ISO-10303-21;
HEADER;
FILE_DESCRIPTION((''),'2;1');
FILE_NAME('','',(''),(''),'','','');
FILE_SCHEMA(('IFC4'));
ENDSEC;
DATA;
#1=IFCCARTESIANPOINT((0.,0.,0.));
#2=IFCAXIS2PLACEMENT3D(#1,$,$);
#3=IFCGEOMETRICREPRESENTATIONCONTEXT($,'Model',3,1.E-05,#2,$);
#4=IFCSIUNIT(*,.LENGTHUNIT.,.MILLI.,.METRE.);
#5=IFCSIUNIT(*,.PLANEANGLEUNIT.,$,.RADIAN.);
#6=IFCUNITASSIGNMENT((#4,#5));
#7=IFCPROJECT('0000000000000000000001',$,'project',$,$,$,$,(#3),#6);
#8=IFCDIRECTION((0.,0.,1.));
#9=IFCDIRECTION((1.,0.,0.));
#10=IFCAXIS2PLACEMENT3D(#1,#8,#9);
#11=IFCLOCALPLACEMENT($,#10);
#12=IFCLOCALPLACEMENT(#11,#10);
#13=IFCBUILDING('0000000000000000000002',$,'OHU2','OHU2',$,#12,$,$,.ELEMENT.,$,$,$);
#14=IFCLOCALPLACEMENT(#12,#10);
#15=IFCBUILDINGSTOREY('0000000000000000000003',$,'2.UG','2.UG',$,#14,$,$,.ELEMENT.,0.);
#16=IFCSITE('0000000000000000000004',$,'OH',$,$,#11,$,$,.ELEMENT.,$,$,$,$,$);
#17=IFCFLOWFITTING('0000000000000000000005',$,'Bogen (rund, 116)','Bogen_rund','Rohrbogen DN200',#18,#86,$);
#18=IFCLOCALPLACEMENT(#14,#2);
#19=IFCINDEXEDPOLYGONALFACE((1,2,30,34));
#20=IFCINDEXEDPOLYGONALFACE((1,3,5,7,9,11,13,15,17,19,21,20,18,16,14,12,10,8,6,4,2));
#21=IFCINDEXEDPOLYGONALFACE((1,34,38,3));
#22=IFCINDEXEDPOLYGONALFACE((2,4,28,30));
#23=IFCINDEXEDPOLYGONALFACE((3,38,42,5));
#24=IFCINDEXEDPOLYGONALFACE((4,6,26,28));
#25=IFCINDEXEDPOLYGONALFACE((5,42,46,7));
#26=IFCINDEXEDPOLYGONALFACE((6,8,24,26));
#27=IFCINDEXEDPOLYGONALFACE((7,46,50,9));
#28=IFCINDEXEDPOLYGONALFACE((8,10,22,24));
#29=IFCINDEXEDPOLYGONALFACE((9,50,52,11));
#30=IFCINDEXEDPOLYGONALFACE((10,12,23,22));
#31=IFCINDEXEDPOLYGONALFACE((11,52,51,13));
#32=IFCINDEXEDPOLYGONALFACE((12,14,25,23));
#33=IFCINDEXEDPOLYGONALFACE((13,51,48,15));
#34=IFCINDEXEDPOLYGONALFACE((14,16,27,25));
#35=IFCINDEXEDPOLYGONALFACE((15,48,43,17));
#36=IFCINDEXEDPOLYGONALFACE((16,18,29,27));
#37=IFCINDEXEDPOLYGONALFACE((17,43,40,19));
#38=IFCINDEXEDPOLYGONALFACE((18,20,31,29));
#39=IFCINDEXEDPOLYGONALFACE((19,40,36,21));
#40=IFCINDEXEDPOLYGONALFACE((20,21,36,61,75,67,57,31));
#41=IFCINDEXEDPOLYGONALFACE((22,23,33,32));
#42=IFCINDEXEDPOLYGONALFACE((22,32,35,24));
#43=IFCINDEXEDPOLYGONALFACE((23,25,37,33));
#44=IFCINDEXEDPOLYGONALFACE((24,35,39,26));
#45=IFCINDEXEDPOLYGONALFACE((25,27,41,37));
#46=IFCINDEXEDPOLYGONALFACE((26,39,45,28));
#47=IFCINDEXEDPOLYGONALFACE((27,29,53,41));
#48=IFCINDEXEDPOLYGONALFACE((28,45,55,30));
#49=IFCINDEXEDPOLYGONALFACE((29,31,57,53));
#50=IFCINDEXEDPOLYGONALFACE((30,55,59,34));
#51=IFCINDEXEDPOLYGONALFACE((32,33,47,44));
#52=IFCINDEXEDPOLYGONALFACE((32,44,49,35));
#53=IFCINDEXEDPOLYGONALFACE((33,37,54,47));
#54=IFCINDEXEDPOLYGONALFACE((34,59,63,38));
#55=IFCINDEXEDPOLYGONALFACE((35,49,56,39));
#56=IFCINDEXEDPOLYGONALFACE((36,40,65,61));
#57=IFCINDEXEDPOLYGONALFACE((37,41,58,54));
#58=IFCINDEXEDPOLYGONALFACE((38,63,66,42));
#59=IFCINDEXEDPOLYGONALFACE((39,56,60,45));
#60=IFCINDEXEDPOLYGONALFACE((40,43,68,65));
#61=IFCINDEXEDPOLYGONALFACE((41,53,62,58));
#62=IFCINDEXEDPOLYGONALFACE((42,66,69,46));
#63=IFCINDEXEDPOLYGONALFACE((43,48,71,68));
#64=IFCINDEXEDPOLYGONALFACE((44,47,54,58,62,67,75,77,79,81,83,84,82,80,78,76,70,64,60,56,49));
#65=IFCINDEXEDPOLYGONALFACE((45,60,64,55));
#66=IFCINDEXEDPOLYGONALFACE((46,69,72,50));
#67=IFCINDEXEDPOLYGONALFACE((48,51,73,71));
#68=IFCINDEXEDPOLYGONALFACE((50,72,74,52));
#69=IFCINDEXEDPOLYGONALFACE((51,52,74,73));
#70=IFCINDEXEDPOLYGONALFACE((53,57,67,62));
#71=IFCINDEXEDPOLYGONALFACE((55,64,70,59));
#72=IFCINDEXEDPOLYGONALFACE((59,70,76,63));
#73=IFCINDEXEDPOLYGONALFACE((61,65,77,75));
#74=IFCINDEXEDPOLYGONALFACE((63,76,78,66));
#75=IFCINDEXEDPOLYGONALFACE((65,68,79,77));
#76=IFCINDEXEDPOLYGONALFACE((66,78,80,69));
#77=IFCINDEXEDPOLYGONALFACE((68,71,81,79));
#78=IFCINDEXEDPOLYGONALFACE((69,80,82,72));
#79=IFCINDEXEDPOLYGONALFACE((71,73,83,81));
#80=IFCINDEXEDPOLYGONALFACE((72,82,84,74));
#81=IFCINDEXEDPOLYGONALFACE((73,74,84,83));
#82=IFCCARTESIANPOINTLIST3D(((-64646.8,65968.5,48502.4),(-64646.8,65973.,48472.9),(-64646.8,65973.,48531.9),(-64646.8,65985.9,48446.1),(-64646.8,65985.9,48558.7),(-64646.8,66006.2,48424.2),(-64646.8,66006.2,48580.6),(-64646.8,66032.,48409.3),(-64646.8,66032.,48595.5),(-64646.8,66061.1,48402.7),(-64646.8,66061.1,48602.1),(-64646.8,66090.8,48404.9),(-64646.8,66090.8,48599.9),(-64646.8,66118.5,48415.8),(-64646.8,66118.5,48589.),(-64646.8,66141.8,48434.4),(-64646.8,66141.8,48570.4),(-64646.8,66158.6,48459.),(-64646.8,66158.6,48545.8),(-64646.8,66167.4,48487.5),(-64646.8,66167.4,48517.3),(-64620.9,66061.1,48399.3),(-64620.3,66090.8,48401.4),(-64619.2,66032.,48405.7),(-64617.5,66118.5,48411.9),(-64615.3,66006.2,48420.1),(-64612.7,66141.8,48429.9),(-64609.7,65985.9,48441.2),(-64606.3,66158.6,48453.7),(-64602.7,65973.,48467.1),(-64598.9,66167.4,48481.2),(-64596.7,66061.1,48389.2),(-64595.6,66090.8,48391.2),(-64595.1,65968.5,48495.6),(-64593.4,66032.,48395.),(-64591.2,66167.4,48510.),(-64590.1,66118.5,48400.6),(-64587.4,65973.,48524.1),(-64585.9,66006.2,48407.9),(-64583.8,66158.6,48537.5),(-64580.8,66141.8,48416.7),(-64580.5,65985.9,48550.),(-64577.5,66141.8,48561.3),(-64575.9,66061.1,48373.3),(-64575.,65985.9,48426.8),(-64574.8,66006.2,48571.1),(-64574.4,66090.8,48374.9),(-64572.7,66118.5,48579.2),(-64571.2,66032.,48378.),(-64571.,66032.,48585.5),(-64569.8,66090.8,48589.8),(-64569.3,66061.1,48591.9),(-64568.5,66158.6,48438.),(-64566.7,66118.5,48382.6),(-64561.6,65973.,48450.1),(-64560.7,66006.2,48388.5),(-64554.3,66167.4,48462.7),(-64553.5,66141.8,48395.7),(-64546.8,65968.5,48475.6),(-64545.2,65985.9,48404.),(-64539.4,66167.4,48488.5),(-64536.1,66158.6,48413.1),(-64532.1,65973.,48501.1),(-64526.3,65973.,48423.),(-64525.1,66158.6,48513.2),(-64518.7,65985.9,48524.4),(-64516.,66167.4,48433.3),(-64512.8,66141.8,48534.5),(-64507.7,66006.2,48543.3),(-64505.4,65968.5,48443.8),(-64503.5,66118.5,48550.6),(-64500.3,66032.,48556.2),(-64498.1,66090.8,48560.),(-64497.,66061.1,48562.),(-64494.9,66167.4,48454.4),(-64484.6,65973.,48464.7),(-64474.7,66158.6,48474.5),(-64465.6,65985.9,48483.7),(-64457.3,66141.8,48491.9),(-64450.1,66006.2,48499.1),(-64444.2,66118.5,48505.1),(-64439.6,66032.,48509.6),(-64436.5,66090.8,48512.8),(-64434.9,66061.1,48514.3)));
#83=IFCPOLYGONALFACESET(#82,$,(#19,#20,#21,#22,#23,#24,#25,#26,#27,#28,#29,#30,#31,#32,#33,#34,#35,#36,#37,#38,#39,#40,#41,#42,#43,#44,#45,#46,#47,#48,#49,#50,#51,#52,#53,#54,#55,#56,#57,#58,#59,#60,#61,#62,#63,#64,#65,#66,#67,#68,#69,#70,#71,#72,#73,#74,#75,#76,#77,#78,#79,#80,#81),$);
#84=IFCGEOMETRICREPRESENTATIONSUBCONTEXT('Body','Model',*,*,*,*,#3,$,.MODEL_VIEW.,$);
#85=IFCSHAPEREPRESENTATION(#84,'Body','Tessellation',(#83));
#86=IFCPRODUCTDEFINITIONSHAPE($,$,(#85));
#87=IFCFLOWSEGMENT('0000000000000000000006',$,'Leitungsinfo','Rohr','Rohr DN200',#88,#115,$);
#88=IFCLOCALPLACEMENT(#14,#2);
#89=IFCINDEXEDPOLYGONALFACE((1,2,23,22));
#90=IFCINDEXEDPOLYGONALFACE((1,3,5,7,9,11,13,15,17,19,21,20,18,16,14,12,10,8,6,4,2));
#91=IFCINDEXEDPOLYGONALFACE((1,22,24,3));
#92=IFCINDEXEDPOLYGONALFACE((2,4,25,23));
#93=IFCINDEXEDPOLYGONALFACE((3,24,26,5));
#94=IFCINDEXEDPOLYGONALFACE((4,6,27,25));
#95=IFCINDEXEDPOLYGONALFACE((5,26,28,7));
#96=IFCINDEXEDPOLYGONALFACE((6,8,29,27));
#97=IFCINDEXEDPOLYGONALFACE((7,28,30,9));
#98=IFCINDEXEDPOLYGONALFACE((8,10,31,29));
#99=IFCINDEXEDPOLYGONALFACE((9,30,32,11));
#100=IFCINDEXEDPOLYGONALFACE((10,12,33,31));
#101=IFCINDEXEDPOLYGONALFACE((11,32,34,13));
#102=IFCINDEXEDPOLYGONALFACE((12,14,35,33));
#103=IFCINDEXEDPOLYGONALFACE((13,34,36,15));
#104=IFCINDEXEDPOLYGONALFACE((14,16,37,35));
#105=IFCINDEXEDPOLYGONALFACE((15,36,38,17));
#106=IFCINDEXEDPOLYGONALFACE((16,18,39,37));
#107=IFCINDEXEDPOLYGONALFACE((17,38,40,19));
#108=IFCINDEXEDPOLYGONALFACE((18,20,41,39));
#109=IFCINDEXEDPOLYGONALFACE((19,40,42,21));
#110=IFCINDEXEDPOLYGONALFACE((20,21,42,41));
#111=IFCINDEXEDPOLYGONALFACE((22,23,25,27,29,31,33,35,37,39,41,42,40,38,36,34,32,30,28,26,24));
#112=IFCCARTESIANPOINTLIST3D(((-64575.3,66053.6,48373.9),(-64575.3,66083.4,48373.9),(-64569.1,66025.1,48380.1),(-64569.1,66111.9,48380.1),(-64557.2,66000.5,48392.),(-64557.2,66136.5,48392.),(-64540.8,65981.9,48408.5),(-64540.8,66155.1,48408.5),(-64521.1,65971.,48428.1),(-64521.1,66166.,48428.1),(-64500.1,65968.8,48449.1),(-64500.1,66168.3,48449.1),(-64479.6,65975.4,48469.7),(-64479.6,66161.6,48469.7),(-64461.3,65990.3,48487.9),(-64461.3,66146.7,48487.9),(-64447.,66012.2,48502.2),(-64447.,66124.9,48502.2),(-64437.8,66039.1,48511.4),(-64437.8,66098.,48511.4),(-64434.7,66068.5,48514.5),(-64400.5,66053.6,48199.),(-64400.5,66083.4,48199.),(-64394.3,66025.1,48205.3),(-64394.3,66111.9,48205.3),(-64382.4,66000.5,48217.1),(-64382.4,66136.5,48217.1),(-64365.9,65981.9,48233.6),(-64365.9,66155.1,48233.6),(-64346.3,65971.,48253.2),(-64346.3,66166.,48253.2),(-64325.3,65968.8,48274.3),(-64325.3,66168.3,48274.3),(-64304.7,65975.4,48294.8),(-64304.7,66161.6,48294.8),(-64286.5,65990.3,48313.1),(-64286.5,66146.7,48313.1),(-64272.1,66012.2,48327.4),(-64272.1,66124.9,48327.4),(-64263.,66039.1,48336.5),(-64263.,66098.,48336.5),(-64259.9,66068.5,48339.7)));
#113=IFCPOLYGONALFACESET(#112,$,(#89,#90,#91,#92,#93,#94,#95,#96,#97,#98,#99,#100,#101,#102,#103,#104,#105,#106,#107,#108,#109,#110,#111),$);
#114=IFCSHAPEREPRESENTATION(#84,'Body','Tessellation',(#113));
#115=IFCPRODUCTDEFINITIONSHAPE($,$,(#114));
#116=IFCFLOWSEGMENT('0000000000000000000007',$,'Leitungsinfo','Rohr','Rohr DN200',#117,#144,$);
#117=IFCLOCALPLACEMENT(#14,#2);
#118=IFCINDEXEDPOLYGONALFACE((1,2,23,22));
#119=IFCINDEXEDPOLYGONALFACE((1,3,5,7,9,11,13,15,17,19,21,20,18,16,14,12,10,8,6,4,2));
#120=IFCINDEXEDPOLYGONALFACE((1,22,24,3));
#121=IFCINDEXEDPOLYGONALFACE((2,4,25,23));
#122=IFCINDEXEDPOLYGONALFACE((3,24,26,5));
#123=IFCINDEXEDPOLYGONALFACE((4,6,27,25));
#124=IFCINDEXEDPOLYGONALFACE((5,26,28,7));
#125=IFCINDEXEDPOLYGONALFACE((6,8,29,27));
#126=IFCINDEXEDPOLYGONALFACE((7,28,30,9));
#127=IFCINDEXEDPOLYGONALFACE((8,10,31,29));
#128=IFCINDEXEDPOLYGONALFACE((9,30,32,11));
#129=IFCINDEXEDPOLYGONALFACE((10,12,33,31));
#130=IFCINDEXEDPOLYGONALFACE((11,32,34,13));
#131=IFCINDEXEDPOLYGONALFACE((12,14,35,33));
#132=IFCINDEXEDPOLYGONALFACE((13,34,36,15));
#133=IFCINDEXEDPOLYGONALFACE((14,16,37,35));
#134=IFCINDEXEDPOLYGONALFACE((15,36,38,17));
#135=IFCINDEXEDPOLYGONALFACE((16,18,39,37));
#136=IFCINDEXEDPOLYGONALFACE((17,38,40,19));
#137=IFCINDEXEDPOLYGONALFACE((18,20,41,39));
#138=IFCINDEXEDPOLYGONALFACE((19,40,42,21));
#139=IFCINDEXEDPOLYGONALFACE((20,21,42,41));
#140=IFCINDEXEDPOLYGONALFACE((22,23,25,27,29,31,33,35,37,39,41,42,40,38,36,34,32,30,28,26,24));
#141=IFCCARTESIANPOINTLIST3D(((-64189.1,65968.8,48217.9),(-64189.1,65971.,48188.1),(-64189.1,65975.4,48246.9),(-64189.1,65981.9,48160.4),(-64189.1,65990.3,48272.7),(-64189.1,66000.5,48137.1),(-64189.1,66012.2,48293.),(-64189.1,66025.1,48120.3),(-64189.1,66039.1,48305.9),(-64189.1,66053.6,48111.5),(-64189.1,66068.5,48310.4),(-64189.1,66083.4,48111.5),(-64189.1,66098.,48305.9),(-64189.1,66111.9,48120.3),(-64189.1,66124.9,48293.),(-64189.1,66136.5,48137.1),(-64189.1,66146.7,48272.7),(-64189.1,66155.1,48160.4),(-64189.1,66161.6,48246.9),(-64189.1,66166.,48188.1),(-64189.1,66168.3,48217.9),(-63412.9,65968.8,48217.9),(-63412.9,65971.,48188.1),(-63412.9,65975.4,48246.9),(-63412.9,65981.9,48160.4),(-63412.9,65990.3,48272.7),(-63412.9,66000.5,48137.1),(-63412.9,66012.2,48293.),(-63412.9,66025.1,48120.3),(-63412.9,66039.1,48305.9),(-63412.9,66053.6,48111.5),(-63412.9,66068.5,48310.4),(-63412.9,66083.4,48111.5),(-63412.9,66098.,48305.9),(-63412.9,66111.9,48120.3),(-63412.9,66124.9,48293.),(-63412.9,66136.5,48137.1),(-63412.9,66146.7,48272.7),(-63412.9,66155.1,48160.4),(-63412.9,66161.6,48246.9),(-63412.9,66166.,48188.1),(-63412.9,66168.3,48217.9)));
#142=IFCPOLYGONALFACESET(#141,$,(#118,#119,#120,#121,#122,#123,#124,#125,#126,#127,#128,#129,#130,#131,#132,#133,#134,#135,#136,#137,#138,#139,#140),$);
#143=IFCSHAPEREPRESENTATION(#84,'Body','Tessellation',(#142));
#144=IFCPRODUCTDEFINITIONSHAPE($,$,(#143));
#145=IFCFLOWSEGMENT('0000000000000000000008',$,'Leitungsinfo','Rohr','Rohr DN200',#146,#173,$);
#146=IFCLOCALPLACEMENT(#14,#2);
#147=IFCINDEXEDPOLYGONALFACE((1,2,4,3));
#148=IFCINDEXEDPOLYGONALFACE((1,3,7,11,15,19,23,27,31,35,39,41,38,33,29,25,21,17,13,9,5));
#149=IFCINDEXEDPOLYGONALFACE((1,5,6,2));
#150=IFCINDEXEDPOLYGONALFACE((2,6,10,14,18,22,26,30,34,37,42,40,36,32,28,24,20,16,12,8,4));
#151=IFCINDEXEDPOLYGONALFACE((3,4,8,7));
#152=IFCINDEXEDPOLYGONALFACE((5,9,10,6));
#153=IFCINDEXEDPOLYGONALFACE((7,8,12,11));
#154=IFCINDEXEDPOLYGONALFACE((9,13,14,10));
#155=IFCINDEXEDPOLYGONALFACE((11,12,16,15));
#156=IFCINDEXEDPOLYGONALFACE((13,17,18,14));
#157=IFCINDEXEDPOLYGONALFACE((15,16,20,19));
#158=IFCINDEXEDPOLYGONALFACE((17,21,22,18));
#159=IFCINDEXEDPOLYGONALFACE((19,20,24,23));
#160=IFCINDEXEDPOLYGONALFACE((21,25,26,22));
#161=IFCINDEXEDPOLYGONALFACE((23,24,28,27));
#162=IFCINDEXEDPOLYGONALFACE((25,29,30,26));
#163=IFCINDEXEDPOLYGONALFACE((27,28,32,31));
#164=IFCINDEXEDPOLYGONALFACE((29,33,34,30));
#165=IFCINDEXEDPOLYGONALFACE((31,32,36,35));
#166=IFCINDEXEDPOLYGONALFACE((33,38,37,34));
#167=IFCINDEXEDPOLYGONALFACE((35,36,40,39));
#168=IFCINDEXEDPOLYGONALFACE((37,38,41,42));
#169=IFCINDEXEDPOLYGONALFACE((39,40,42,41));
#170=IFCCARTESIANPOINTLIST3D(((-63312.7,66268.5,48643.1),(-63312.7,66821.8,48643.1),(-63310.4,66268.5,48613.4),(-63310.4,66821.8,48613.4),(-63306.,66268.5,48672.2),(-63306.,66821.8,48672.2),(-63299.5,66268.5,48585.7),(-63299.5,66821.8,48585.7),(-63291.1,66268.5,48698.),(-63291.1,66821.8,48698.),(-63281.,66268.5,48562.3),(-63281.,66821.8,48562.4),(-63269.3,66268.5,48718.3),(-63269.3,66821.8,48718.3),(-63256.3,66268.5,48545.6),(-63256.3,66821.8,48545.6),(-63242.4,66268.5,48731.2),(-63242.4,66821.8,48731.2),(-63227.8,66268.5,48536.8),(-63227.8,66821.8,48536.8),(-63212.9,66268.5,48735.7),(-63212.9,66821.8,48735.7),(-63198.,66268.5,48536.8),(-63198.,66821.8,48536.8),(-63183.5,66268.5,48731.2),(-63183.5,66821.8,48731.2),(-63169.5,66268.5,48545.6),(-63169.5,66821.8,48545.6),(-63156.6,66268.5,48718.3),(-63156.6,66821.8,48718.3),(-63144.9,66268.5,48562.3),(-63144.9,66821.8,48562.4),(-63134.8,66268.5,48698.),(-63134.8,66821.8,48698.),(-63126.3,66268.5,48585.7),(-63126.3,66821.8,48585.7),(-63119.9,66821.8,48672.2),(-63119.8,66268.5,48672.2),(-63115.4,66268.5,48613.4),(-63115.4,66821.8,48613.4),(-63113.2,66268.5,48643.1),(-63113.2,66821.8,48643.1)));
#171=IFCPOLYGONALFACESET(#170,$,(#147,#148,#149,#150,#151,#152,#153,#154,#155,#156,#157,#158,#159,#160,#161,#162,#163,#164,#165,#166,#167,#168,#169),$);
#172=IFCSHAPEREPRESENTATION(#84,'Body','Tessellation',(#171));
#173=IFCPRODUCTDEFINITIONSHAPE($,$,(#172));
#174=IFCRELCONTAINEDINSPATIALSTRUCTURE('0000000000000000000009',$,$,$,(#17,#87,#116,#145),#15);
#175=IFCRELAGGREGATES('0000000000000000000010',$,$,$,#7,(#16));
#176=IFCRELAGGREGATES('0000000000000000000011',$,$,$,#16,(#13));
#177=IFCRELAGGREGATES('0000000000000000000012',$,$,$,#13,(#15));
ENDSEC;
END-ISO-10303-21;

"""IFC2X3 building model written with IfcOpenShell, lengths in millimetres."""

from ifc_helpers import new_model, entity, si_unit, frame, origin, origin_with_axes, origin_2d_with_axis, place, context, subcontext, project, spatial, circle, extrude, element, save


model = new_model("IFC2X3")

# Units and contexts
model_context = context("Model", 3, precision=1e-05, world=origin())
body_context = subcontext(model_context, "Body", "Model", "MODEL_VIEW")
ifc_project = project(units=[si_unit("LENGTHUNIT", "METRE", prefix="MILLI"), si_unit("PLANEANGLEUNIT", "RADIAN")], contexts=[model_context])

# Site, building, storey
site_placement = place(None, origin_with_axes())
site = spatial("IfcSite", under=ifc_project, at=site_placement, Name="OH", CompositionType="ELEMENT")
building_placement = place(site_placement, origin_with_axes())
building = spatial("IfcBuilding", under=site, at=building_placement, Name="OHU2", Description="OHU2", CompositionType="ELEMENT")
storey_placement = place(building_placement, origin_with_axes())
storey = spatial("IfcBuildingStorey", under=building, at=storey_placement, Name="2.UG", Description="2.UG", CompositionType="ELEMENT", Elevation=0.0)

# Flow fitting
flow_fitting_1_placement = place(storey_placement, frame((-64547.8, 66068.5, 48487.8), z_axis=(0.0, 0.0, 1.0), x_axis=(1.0, 0.0, 0.0)))
element("IfcFlowFitting", 1, at=flow_fitting_1_placement, inside=storey, Name="Bogen (rund, 116)", Description="Bogen_rund", ObjectType="Rohrbogen DN200", context=body_context, shape_type="SweptSolid", body=[
    entity("IfcRevolvedAreaSolid", entity("IfcCircleProfileDef", "AREA", None, entity("IfcAxis2Placement2D", entity("IfcCartesianPoint", [0.0, 0.0]), entity("IfcDirection", [1.0, 0.0])), 100.0), entity("IfcAxis2Placement3D", entity("IfcCartesianPoint", [-99.0, 0.0, 14.6]), entity("IfcDirection", [1.0, 0.0, 0.0]), entity("IfcDirection", [0.0, -1.0, 0.0])), entity("IfcAxis1Placement", entity("IfcCartesianPoint", [0.0, 200.0, 0.0]), entity("IfcDirection", [-1.0, 0.0, 0.0])), 0.785398),
])

# Flow segments
flow_segment_1_placement = place(storey_placement, frame((-64418.0, 66068.7, 48356.4), z_axis=(0.0, 0.0, 1.0), x_axis=(1.0, 0.0, 0.0)))
element("IfcFlowSegment", 2, at=flow_segment_1_placement, inside=storey, Name="Leitungsinfo", Description="Rohr", ObjectType="Rohr DN200", context=body_context, shape_type="SweptSolid", body=[
    extrude(circle(Radius=100.0, at=origin_2d_with_axis()), frame((-87.4, -0.2, 87.4), z_axis=(0.707107, 0.0, -0.707107), x_axis=(0.0, 0.0, 1.0)), (0.0, 0.0, 1.0), 247.3),
])
flow_segment_2_placement = place(storey_placement, frame((-63801.0, 66068.7, 48210.4), z_axis=(0.0, 0.0, 1.0), x_axis=(1.0, 0.0, 0.0)))
element("IfcFlowSegment", 3, at=flow_segment_2_placement, inside=storey, Name="Leitungsinfo", Description="Rohr", ObjectType="Rohr DN200", context=body_context, shape_type="SweptSolid", body=[
    extrude(circle(Radius=100.0, at=origin_2d_with_axis()), frame((-388.1, -0.2, 0.0), z_axis=(1.0, 0.0, 0.0), x_axis=(0.0, 0.0, 1.0)), (0.0, 0.0, 1.0), 776.2),
])
flow_segment_3_placement = place(storey_placement, frame((-63212.8, 66545.2, 48635.7), z_axis=(0.0, 0.0, 1.0), x_axis=(1.0, 0.0, 0.0)))
element("IfcFlowSegment", 4, at=flow_segment_3_placement, inside=storey, Name="Leitungsinfo", Description="Rohr", ObjectType="Rohr DN200", context=body_context, shape_type="SweptSolid", body=[
    extrude(circle(Radius=100.0, at=origin_2d_with_axis()), frame((-0.2, 276.6, 0.0), z_axis=(0.000006, -1.0, -0.000006), x_axis=(0.0, 0.0, 1.0)), (0.0, 0.0, 1.0), 553.3),
])

save(model, "model.ifc")
